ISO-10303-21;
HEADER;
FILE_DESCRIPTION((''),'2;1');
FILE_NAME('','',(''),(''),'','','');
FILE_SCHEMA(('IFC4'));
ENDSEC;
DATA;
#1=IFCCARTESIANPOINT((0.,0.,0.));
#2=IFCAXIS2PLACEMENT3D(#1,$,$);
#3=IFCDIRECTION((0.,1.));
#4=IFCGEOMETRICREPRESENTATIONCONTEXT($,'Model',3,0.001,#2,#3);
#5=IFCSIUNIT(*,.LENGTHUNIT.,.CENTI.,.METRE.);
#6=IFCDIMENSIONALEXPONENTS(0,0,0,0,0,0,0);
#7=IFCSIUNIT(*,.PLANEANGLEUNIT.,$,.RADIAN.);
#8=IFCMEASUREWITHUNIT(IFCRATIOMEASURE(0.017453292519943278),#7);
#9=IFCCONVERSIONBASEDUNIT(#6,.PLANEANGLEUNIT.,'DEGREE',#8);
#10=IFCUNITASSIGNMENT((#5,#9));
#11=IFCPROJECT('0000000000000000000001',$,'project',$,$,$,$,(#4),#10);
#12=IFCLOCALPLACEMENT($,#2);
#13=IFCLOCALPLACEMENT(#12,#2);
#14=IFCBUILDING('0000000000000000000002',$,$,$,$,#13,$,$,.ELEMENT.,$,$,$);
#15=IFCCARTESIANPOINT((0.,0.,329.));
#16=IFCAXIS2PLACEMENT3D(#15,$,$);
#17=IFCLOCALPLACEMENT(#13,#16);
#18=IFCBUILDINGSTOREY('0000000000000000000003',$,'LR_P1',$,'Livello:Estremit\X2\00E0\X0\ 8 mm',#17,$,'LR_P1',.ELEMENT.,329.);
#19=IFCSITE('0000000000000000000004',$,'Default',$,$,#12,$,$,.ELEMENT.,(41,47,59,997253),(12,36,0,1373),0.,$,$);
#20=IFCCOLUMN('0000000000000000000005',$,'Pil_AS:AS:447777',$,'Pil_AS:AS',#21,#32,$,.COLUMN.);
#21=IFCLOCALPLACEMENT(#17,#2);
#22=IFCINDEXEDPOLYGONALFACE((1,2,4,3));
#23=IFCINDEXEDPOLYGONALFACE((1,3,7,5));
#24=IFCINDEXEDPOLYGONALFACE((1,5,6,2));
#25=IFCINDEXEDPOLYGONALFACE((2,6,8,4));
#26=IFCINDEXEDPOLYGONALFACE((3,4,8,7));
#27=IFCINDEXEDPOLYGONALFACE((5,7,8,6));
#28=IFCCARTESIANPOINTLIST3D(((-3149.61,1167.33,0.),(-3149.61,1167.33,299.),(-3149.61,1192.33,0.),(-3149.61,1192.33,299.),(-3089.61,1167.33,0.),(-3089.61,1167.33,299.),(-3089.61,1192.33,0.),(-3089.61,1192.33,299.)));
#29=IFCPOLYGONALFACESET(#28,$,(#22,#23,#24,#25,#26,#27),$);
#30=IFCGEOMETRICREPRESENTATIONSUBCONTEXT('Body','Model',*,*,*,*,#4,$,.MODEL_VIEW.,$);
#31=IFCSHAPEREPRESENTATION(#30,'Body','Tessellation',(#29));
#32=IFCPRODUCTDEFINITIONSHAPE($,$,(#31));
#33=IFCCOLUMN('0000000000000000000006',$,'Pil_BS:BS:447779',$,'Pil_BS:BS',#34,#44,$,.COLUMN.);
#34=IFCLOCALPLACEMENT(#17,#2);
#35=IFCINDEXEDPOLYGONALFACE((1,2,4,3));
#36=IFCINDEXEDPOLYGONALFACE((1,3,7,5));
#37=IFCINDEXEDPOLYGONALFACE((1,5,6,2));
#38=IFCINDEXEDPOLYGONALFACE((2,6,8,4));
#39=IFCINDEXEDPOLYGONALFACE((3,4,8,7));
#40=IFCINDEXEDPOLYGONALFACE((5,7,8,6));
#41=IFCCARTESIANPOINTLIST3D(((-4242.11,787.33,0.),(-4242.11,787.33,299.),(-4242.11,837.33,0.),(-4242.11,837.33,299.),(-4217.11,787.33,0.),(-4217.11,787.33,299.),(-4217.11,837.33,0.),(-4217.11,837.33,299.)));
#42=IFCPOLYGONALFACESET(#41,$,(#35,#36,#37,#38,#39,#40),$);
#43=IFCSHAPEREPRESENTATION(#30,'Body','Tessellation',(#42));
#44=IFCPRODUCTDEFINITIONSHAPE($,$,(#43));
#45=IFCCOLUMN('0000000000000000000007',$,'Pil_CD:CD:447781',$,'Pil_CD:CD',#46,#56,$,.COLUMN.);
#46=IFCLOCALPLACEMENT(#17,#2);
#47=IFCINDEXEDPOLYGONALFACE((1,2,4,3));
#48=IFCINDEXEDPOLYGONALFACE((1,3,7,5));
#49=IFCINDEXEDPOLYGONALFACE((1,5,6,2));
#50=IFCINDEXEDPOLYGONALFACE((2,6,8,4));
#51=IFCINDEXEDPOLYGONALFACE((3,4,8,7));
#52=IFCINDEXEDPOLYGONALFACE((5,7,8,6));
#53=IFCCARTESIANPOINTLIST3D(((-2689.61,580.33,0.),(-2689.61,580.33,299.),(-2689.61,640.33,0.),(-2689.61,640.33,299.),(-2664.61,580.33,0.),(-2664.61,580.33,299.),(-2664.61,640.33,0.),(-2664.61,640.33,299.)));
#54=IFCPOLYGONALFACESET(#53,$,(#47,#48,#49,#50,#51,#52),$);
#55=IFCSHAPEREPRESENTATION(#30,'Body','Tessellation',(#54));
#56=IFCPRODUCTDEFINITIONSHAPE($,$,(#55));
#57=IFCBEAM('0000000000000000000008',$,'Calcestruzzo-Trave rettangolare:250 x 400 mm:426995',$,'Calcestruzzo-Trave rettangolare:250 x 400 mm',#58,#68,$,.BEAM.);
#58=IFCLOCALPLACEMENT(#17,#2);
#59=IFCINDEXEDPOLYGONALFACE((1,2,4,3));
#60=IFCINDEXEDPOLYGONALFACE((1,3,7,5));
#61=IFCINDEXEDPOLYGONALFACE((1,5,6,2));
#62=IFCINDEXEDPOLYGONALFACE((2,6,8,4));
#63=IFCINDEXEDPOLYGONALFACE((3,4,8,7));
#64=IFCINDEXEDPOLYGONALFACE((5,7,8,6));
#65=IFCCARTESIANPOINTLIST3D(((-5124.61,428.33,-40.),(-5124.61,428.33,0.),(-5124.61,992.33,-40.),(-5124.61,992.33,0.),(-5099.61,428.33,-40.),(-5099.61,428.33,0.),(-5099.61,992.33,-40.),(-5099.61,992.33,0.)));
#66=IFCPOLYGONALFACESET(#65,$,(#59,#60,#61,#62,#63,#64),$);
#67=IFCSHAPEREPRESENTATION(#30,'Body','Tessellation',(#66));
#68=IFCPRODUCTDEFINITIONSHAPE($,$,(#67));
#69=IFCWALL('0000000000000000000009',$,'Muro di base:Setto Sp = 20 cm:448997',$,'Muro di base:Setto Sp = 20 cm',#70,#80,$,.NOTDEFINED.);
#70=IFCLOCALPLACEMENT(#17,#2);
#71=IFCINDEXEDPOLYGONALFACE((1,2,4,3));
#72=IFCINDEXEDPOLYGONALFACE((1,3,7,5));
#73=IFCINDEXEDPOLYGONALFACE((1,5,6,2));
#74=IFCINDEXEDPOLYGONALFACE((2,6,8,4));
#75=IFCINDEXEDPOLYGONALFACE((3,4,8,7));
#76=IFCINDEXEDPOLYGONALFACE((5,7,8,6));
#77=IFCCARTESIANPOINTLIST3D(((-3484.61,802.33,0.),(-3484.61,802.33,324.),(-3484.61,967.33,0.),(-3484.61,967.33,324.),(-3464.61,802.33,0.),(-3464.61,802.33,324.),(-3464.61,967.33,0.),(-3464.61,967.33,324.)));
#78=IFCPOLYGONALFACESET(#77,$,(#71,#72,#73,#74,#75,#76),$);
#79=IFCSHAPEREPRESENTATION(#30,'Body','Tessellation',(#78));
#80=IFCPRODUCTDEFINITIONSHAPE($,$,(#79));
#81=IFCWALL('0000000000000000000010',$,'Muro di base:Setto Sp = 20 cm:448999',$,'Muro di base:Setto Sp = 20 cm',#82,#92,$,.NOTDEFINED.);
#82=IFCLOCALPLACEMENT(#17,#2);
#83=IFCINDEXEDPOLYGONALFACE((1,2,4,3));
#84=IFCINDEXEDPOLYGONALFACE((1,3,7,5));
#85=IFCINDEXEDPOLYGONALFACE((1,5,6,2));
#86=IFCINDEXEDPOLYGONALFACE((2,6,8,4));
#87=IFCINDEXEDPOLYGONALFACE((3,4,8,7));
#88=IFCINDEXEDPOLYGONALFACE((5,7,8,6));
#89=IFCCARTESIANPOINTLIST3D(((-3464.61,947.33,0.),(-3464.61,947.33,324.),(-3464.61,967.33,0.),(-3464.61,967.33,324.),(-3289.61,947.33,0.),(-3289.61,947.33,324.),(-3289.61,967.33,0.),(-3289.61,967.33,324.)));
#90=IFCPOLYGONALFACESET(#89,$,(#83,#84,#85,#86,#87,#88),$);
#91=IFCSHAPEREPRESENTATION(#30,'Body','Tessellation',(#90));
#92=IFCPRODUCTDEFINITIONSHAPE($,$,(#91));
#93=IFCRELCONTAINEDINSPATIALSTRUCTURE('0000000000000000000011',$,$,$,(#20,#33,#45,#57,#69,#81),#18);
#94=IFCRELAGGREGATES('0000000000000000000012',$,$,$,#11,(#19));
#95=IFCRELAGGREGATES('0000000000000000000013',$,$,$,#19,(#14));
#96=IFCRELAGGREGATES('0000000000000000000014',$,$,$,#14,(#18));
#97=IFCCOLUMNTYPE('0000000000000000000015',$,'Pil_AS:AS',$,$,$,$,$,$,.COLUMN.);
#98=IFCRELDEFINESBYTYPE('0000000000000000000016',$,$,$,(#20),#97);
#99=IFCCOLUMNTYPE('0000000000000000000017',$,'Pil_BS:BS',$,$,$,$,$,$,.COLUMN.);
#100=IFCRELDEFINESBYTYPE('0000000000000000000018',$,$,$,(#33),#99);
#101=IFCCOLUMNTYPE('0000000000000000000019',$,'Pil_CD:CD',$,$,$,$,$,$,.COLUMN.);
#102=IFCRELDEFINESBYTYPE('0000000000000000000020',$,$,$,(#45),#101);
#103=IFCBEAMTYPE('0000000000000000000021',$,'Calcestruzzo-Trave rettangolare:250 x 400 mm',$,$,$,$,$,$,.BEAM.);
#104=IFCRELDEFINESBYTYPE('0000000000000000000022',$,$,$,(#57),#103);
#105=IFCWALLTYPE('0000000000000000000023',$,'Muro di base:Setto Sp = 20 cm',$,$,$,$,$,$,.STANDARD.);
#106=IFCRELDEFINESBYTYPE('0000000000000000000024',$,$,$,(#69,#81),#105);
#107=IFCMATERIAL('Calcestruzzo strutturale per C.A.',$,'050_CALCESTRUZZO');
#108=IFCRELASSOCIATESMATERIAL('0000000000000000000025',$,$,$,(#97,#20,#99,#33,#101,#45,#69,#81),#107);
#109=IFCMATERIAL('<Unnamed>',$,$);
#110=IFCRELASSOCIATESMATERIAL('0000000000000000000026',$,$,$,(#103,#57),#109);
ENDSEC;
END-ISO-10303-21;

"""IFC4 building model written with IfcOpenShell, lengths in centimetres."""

from ifc_helpers import new_model, entity, si_unit, converted_unit, direction, frame, origin, place, context, subcontext, project, spatial, indexed_curve, outline, extrude, source, transform, mapped, material, type_object, type_shapes, element, save


model = new_model("IFC4")

# Units and contexts
model_context = context("Model", 3, precision=0.001, world=origin(), true_north=direction((0.0, 1.0)))
body_context = subcontext(model_context, "Body", "Model", "MODEL_VIEW")
ifc_project = project(units=[si_unit("LENGTHUNIT", "METRE", prefix="CENTI"), converted_unit("PLANEANGLEUNIT", "DEGREE", entity("IfcRatioMeasure", 0.017453292519943278), si_unit("PLANEANGLEUNIT", "RADIAN"), dimensions=[0, 0, 0, 0, 0, 0, 0])], contexts=[model_context])

# Site, building, storey
site_placement = place(None, origin())
site = spatial("IfcSite", under=ifc_project, at=site_placement, Name="Default", CompositionType="ELEMENT", RefLatitude=(41, 47, 59, 997253), RefLongitude=(12, 36, 0, 1373), RefElevation=0.0)
building_placement = place(site_placement, origin())
building = spatial("IfcBuilding", under=site, at=building_placement, CompositionType="ELEMENT")
storey_placement = place(building_placement, frame((0.0, 0.0, 329.0)))
storey = spatial("IfcBuildingStorey", under=building, at=storey_placement, Name="LR_P1", ObjectType="Livello:Estremità 8 mm", LongName="LR_P1", CompositionType="ELEMENT", Elevation=329.0)

# Columns
ifc_material_1 = material(Name="Calcestruzzo strutturale per C.A.", Category="050_CALCESTRUZZO")
column_type_1 = type_object("IfcColumnType", Name="Pil_AS:AS", PredefinedType="COLUMN", material=ifc_material_1)
shared_shape_1 = source(origin(), body_context, "Body", "SweptSolid", [
    extrude(outline(indexed_curve([(-12.5, -30.0), (12.5, -30.0), (12.5, 30.0), (-12.5, 30.0), (-12.5, -30.0)], self_intersect=False)), frame((-3119.61, 1179.83, 329.0), z_axis=(0.0, 0.0, 1.0), x_axis=(0.0, -1.0, 0.0)), (0.0, 0.0, 1.0), 299.0),
])
type_shapes(column_type_1, [shared_shape_1])
column_1_placement = place(storey_placement, frame((0.0, 0.0, -329.0)))
element("IfcColumn", 1, at=column_1_placement, inside=storey, type_object=column_type_1, material=ifc_material_1, Name="Pil_AS:AS:447777", ObjectType="Pil_AS:AS", PredefinedType="COLUMN", context=body_context, shape_type="MappedRepresentation", body=[
    mapped(shared_shape_1, transform((0.0, 0.0, 0.0), scale=1.0)),
])
column_type_2 = type_object("IfcColumnType", Name="Pil_BS:BS", PredefinedType="COLUMN", material=ifc_material_1)
shared_shape_2 = source(origin(), body_context, "Body", "SweptSolid", [
    extrude(outline(indexed_curve([(-25.0, -12.5), (25.0, -12.5), (25.0, 12.5), (-25.0, 12.5), (-25.0, -12.5)], self_intersect=False)), frame((-4229.61, 812.33, 329.0), z_axis=(0.0, 0.0, 1.0), x_axis=(0.0, -1.0, 0.0)), (0.0, 0.0, 1.0), 299.0),
])
type_shapes(column_type_2, [shared_shape_2])
column_2_placement = place(storey_placement, frame((0.0, 0.0, -329.0)))
element("IfcColumn", 2, at=column_2_placement, inside=storey, type_object=column_type_2, material=ifc_material_1, Name="Pil_BS:BS:447779", ObjectType="Pil_BS:BS", PredefinedType="COLUMN", context=body_context, shape_type="MappedRepresentation", body=[
    mapped(shared_shape_2, transform((0.0, 0.0, 0.0), scale=1.0)),
])
column_type_3 = type_object("IfcColumnType", Name="Pil_CD:CD", PredefinedType="COLUMN", material=ifc_material_1)
shared_shape_3 = source(origin(), body_context, "Body", "SweptSolid", [
    extrude(outline(indexed_curve([(-30.0, -12.5), (30.0, -12.5), (30.0, 12.5), (-30.0, 12.5), (-30.0, -12.5)], self_intersect=False)), frame((-2677.11, 610.33, 329.0), z_axis=(0.0, 0.0, 1.0), x_axis=(0.0, -1.0, 0.0)), (0.0, 0.0, 1.0), 299.0),
])
type_shapes(column_type_3, [shared_shape_3])
column_3_placement = place(storey_placement, frame((0.0, 0.0, -329.0)))
element("IfcColumn", 3, at=column_3_placement, inside=storey, type_object=column_type_3, material=ifc_material_1, Name="Pil_CD:CD:447781", ObjectType="Pil_CD:CD", PredefinedType="COLUMN", context=body_context, shape_type="MappedRepresentation", body=[
    mapped(shared_shape_3, transform((0.0, 0.0, 0.0), scale=1.0)),
])

# Beam
ifc_material_2 = material(Name="<Unnamed>")
beam_type_1 = type_object("IfcBeamType", Name="Calcestruzzo-Trave rettangolare:250 x 400 mm", PredefinedType="BEAM", material=ifc_material_2)
shared_shape_4 = source(origin(), body_context, "Body", "SweptSolid", [
    extrude(outline(indexed_curve([(-12.5, -20.0), (12.5, -20.0), (12.5, 20.0), (-12.5, 20.0), (-12.5, -20.0)], self_intersect=False)), frame((-5112.11, 428.33, 309.0), z_axis=(0.0, 1.0, 0.0), x_axis=(-1.0, 0.0, 0.0)), (0.0, 0.0, 1.0), 564.0),
])
type_shapes(beam_type_1, [shared_shape_4])
beam_1_placement = place(storey_placement, frame((0.0, 0.0, -329.0)))
element("IfcBeam", 4, at=beam_1_placement, inside=storey, type_object=beam_type_1, material=ifc_material_2, Name="Calcestruzzo-Trave rettangolare:250 x 400 mm:426995", ObjectType="Calcestruzzo-Trave rettangolare:250 x 400 mm", PredefinedType="BEAM", context=body_context, shape_type="MappedRepresentation", body=[
    mapped(shared_shape_4, transform((0.0, 0.0, 0.0), scale=1.0)),
])

# Walls
wall_type = type_object("IfcWallType", Name="Muro di base:Setto Sp = 20 cm", PredefinedType="STANDARD")
wall_1_placement = place(storey_placement, frame((-3474.61, 802.33, 0.0), z_axis=(0.0, 0.0, 1.0), x_axis=(0.0, 1.0, 0.0)))
element("IfcWall", 5, at=wall_1_placement, inside=storey, type_object=wall_type, material=ifc_material_1, Name="Muro di base:Setto Sp = 20 cm:448997", ObjectType="Muro di base:Setto Sp = 20 cm", PredefinedType="NOTDEFINED", context=body_context, shape_type="SweptSolid", body=[
    extrude(outline(indexed_curve([(165.0, 10.0), (0.0, 10.0), (0.0, -10.0), (165.0, -10.0), (165.0, 10.0)], self_intersect=False)), origin(), (0.0, 0.0, 1.0), 324.0),
])
wall_2_placement = place(storey_placement, frame((-3464.61, 957.33, 0.0)))
element("IfcWall", 6, at=wall_2_placement, inside=storey, type_object=wall_type, material=ifc_material_1, Name="Muro di base:Setto Sp = 20 cm:448999", ObjectType="Muro di base:Setto Sp = 20 cm", PredefinedType="NOTDEFINED", context=body_context, shape_type="SweptSolid", body=[
    extrude(outline(indexed_curve([(175.0, 10.0), (0.0, 10.0), (0.0, -10.0), (175.0, -10.0), (175.0, 10.0)], self_intersect=False)), origin(), (0.0, 0.0, 1.0), 324.0),
])

save(model, "model.ifc")
